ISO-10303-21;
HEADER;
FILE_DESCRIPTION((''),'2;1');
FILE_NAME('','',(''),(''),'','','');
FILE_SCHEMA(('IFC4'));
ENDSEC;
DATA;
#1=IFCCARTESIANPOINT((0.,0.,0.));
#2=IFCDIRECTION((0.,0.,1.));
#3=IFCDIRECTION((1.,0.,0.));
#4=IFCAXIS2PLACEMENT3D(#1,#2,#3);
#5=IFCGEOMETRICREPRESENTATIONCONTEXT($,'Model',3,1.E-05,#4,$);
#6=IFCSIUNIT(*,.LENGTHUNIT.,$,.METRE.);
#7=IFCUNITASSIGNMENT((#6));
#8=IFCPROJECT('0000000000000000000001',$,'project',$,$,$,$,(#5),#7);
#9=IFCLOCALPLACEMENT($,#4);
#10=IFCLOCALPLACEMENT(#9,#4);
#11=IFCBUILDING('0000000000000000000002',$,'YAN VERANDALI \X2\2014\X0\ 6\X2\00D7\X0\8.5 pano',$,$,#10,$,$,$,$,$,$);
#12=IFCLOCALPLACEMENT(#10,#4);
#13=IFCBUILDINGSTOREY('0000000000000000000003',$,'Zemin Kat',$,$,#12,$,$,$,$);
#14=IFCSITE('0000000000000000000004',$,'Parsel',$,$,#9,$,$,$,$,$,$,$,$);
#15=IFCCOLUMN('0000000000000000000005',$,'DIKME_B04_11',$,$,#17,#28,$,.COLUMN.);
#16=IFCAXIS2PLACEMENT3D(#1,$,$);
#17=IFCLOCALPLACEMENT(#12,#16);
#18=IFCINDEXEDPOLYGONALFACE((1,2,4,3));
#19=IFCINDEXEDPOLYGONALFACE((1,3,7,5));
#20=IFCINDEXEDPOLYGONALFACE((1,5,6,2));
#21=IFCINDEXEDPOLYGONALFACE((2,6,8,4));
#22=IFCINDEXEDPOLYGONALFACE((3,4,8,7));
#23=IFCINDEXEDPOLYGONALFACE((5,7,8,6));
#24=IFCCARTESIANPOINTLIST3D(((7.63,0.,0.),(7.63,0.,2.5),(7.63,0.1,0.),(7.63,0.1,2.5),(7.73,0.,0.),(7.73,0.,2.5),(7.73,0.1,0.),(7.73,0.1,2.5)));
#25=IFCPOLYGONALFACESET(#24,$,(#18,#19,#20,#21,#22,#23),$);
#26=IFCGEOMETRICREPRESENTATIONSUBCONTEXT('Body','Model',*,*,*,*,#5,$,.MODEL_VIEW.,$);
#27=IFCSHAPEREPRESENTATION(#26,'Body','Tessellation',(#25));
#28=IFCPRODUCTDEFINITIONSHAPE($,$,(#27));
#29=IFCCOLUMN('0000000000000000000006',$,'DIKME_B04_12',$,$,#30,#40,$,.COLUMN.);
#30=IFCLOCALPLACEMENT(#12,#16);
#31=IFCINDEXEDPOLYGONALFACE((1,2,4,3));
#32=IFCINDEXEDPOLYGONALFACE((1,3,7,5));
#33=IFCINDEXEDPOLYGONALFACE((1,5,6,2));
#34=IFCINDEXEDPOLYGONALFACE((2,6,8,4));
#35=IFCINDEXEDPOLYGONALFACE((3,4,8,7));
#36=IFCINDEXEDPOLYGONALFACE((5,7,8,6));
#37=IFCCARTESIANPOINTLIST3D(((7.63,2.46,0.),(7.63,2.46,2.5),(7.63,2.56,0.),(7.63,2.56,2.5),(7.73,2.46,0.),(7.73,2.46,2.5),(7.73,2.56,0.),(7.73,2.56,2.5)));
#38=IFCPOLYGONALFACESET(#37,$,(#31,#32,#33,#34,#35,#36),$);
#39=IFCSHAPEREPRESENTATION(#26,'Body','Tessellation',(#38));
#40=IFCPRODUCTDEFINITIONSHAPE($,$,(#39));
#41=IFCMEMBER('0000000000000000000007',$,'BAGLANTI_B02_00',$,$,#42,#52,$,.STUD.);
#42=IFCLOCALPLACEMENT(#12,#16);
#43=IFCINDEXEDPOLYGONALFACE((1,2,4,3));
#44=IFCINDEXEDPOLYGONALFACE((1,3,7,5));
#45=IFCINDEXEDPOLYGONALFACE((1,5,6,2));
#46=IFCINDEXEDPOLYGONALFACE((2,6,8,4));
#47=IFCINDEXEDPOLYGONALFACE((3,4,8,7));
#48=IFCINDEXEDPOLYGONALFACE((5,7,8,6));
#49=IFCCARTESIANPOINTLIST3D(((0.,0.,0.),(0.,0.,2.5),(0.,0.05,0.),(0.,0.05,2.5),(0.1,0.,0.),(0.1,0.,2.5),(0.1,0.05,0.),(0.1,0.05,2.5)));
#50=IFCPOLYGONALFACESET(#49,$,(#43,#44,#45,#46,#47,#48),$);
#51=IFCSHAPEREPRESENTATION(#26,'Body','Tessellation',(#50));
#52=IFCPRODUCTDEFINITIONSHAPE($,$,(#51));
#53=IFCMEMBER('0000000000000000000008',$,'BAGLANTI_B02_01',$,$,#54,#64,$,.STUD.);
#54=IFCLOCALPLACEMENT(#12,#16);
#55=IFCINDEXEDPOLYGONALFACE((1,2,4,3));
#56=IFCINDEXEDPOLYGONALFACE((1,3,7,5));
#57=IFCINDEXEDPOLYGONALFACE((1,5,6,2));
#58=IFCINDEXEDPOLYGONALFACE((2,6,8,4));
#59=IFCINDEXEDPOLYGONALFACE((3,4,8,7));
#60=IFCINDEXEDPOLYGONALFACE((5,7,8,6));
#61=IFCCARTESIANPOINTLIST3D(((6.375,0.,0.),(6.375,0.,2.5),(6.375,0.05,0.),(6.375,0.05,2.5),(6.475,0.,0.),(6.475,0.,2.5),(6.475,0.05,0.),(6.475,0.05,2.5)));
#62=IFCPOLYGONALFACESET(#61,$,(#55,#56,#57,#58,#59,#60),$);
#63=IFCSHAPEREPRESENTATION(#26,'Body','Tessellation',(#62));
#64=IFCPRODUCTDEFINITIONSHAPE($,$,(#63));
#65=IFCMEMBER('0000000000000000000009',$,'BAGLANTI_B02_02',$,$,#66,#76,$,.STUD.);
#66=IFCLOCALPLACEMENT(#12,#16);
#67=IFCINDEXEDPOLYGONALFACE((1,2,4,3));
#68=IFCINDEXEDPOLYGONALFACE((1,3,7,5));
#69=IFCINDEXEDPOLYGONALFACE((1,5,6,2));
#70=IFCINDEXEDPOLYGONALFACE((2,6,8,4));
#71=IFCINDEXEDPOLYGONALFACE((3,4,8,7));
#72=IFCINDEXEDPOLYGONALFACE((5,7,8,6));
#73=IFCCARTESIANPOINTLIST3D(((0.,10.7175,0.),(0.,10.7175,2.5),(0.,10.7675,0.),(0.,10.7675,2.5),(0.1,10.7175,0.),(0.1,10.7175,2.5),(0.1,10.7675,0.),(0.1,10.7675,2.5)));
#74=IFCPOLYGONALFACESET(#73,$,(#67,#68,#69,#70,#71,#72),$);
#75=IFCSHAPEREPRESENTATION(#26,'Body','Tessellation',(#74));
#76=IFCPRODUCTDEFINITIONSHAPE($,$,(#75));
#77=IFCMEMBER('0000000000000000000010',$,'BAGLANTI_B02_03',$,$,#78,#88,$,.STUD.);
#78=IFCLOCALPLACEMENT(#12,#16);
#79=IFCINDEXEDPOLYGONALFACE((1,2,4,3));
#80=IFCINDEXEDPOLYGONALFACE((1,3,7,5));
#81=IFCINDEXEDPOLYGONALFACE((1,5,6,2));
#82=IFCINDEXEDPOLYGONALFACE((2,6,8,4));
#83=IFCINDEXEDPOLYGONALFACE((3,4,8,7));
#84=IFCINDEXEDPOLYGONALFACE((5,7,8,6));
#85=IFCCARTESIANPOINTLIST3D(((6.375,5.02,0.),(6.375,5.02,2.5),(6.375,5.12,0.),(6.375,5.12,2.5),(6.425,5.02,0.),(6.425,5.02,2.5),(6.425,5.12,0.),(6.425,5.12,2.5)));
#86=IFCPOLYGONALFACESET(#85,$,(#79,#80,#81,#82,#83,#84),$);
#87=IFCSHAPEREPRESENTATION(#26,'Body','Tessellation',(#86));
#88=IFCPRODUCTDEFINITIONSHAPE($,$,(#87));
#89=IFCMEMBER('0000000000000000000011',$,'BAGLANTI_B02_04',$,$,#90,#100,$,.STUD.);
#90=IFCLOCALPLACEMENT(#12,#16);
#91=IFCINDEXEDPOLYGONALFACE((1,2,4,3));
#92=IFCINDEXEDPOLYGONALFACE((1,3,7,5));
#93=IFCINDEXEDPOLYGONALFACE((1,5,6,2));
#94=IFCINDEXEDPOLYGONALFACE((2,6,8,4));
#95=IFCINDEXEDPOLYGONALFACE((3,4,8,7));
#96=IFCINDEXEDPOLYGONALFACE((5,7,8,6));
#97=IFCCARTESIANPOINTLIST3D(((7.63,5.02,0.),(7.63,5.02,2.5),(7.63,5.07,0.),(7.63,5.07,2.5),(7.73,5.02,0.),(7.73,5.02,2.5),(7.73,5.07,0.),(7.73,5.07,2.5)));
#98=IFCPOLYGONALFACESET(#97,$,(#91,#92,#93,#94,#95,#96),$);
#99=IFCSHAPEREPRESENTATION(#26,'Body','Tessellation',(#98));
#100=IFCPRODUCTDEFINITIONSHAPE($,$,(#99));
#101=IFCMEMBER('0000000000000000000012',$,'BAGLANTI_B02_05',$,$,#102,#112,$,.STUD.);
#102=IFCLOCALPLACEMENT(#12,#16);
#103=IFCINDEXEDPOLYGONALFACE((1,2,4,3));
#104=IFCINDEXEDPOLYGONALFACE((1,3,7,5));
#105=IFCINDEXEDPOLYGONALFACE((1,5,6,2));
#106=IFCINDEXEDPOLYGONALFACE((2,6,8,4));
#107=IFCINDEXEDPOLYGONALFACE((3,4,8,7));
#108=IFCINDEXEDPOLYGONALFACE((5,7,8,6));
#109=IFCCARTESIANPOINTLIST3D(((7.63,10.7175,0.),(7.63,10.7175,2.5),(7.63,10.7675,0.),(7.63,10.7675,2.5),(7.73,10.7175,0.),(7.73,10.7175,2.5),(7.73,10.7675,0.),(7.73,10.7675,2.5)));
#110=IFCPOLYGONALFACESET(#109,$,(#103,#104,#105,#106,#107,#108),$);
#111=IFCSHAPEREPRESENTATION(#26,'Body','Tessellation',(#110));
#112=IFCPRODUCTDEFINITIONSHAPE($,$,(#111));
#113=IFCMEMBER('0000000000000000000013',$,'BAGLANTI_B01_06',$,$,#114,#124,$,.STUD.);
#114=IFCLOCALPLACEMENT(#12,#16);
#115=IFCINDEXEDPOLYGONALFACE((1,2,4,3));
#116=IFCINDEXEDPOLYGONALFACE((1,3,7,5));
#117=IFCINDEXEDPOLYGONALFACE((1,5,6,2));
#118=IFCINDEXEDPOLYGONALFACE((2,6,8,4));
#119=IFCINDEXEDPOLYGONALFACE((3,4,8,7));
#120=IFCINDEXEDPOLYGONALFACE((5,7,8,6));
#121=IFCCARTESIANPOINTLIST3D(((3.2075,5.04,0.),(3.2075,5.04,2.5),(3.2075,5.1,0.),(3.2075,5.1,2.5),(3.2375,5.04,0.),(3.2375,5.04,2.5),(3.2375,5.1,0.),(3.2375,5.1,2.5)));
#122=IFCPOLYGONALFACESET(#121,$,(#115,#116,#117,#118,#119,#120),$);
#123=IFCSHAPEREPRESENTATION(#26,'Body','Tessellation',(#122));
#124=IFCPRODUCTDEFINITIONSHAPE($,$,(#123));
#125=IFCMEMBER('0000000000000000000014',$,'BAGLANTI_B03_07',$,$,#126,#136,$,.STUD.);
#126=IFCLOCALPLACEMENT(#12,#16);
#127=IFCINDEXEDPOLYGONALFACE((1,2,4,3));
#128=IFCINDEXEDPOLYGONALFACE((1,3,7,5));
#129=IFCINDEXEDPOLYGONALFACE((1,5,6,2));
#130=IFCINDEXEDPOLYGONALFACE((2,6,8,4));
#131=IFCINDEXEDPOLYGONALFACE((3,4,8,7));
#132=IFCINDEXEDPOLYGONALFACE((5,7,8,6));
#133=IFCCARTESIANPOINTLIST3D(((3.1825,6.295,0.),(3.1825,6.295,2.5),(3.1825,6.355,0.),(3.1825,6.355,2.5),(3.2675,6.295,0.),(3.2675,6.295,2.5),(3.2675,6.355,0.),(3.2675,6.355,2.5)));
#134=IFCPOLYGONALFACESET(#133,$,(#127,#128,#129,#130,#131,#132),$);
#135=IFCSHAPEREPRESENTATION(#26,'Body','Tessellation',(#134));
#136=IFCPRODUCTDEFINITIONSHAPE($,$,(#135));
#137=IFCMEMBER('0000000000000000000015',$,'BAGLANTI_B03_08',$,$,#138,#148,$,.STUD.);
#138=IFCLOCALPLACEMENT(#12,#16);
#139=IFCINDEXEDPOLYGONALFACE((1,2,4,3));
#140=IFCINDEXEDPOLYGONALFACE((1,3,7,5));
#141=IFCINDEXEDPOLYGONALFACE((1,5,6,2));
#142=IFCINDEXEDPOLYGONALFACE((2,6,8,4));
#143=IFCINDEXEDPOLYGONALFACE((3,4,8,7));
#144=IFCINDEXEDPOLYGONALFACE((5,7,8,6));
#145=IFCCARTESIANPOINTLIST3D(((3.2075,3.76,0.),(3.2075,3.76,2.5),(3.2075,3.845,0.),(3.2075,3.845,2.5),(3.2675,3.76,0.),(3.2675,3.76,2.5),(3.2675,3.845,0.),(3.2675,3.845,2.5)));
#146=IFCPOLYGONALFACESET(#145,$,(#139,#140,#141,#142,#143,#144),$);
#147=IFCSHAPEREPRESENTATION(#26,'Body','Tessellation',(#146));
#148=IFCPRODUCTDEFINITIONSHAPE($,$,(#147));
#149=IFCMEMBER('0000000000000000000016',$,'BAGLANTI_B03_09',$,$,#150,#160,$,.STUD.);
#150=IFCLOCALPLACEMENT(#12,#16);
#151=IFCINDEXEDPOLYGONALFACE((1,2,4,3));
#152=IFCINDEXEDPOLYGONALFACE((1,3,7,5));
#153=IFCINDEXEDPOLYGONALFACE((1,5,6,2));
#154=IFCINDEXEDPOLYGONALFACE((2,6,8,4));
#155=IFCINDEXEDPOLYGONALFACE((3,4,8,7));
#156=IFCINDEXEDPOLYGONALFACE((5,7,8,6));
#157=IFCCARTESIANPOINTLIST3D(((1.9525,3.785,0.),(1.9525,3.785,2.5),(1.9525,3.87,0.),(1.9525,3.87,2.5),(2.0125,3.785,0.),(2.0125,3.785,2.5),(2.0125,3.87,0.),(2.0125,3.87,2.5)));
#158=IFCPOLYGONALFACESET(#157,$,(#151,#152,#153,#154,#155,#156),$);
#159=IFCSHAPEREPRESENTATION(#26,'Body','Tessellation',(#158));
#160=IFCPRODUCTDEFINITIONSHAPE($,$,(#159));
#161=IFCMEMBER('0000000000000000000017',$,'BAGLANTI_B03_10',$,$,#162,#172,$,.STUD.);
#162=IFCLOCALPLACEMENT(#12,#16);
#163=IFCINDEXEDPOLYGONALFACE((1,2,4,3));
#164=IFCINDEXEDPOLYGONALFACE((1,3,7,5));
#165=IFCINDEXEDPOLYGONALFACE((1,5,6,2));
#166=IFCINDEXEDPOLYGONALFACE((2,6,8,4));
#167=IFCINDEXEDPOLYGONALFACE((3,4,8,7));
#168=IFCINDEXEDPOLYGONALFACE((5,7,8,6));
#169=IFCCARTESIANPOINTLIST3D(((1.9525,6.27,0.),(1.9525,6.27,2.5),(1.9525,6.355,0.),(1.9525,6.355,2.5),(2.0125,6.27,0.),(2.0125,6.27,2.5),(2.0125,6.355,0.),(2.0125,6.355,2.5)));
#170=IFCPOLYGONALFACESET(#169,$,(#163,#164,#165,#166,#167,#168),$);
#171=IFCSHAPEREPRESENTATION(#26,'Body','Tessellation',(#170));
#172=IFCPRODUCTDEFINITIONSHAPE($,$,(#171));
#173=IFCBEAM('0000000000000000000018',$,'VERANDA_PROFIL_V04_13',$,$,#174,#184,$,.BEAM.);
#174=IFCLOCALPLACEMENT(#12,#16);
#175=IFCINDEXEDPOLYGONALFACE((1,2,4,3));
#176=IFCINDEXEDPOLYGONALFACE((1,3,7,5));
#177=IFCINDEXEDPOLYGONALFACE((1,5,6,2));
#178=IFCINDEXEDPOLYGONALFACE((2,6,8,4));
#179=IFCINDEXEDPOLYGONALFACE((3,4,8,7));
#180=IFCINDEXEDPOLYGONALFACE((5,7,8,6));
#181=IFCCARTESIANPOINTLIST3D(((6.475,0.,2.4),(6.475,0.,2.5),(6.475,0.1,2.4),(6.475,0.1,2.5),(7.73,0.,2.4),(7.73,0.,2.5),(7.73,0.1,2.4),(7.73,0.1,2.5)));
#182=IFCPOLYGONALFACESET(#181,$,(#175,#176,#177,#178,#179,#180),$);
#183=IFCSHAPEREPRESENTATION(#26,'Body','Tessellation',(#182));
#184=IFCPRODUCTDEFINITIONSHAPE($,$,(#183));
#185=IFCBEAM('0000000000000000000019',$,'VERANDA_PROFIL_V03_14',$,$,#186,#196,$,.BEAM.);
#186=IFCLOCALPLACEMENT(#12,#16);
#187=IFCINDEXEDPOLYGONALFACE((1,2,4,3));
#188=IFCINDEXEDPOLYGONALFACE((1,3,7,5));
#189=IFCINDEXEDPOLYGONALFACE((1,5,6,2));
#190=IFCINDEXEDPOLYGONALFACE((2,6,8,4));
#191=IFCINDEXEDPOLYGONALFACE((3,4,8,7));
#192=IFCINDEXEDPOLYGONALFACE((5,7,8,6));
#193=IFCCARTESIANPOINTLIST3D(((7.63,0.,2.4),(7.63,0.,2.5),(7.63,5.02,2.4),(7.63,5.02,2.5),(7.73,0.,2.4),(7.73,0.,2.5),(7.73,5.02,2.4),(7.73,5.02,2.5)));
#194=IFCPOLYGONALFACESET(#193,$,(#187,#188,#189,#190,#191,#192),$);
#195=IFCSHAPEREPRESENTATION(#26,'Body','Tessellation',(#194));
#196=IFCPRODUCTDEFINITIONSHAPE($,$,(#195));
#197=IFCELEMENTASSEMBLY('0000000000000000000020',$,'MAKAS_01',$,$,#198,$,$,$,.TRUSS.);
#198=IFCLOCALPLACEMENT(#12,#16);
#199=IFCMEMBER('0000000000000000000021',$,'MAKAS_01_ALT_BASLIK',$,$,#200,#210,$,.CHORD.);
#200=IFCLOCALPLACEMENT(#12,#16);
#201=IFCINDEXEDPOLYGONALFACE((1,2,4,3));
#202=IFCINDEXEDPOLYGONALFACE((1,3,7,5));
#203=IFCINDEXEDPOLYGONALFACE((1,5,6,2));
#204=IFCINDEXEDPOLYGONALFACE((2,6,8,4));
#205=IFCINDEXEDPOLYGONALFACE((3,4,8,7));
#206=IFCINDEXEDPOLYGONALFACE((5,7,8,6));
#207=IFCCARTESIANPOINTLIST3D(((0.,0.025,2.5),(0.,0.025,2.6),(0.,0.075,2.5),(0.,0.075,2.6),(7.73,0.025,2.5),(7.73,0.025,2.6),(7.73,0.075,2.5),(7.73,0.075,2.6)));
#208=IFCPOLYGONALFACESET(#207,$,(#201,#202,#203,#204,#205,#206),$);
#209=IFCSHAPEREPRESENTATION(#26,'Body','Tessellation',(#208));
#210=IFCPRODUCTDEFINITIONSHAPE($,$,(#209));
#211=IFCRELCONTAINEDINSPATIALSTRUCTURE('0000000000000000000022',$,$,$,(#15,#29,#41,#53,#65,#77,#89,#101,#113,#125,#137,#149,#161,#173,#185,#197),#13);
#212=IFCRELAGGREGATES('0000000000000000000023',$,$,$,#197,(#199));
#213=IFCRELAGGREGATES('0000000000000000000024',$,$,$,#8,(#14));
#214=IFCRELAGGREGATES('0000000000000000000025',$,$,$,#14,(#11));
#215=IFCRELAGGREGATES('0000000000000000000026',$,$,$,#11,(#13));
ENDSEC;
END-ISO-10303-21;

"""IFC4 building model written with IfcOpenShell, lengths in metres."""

from ifc_helpers import new_model, si_unit, frame, origin_with_axes, place, context, subcontext, project, spatial, line, indexed_curve, outline, extrude, element, aggregate, save


model = new_model("IFC4")

# Units and contexts
model_context = context("Model", 3, precision=1e-05, world=origin_with_axes())
body_context = subcontext(model_context, "Body", "Model", "MODEL_VIEW")
ifc_project = project(units=[si_unit("LENGTHUNIT", "METRE")], contexts=[model_context])

# Site, building, storey
site_placement = place(None, origin_with_axes())
site = spatial("IfcSite", under=ifc_project, at=site_placement, Name="Parsel")
building_placement = place(site_placement, origin_with_axes())
building = spatial("IfcBuilding", under=site, at=building_placement, Name="YAN VERANDALI — 6×8.5 pano")
storey_placement = place(building_placement, origin_with_axes())
storey = spatial("IfcBuildingStorey", under=building, at=storey_placement, Name="Zemin Kat")

# Columns
column_1_placement = place(storey_placement, origin_with_axes())
element("IfcColumn", 1, at=column_1_placement, inside=storey, Name="DIKME_B04_11", PredefinedType="COLUMN", context=body_context, shape_type="SweptSolid", body=[
    extrude(outline(indexed_curve([(7.63, 0.0), (7.73, 0.0), (7.73, 0.1), (7.63, 0.1)], segments=[line(1, 2, 3, 4, 1)])), origin_with_axes(), (0.0, 0.0, 1.0), 2.5),
])
column_2_placement = place(storey_placement, origin_with_axes())
element("IfcColumn", 2, at=column_2_placement, inside=storey, Name="DIKME_B04_12", PredefinedType="COLUMN", context=body_context, shape_type="SweptSolid", body=[
    extrude(outline(indexed_curve([(7.63, 2.46), (7.73, 2.46), (7.73, 2.56), (7.63, 2.56)], segments=[line(1, 2, 3, 4, 1)])), origin_with_axes(), (0.0, 0.0, 1.0), 2.5),
])

# Members
member_1_placement = place(storey_placement, origin_with_axes())
element("IfcMember", 3, at=member_1_placement, inside=storey, Name="BAGLANTI_B02_00", PredefinedType="STUD", context=body_context, shape_type="SweptSolid", body=[
    extrude(outline(indexed_curve([(0.0, 0.0), (0.1, 0.0), (0.1, 0.05), (0.0, 0.05)], segments=[line(1, 2, 3, 4, 1)])), origin_with_axes(), (0.0, 0.0, 1.0), 2.5),
])
member_2_placement = place(storey_placement, origin_with_axes())
element("IfcMember", 4, at=member_2_placement, inside=storey, Name="BAGLANTI_B02_01", PredefinedType="STUD", context=body_context, shape_type="SweptSolid", body=[
    extrude(outline(indexed_curve([(6.375, 0.0), (6.475, 0.0), (6.475, 0.05), (6.375, 0.05)], segments=[line(1, 2, 3, 4, 1)])), origin_with_axes(), (0.0, 0.0, 1.0), 2.5),
])
member_3_placement = place(storey_placement, origin_with_axes())
element("IfcMember", 5, at=member_3_placement, inside=storey, Name="BAGLANTI_B02_02", PredefinedType="STUD", context=body_context, shape_type="SweptSolid", body=[
    extrude(outline(indexed_curve([(0.0, 10.7175), (0.1, 10.7175), (0.1, 10.7675), (0.0, 10.7675)], segments=[line(1, 2, 3, 4, 1)])), origin_with_axes(), (0.0, 0.0, 1.0), 2.5),
])
member_4_placement = place(storey_placement, origin_with_axes())
element("IfcMember", 6, at=member_4_placement, inside=storey, Name="BAGLANTI_B02_03", PredefinedType="STUD", context=body_context, shape_type="SweptSolid", body=[
    extrude(outline(indexed_curve([(6.375, 5.02), (6.425, 5.02), (6.425, 5.12), (6.375, 5.12)], segments=[line(1, 2, 3, 4, 1)])), origin_with_axes(), (0.0, 0.0, 1.0), 2.5),
])
member_5_placement = place(storey_placement, origin_with_axes())
element("IfcMember", 7, at=member_5_placement, inside=storey, Name="BAGLANTI_B02_04", PredefinedType="STUD", context=body_context, shape_type="SweptSolid", body=[
    extrude(outline(indexed_curve([(7.63, 5.02), (7.73, 5.02), (7.73, 5.07), (7.63, 5.07)], segments=[line(1, 2, 3, 4, 1)])), origin_with_axes(), (0.0, 0.0, 1.0), 2.5),
])
member_6_placement = place(storey_placement, origin_with_axes())
element("IfcMember", 8, at=member_6_placement, inside=storey, Name="BAGLANTI_B02_05", PredefinedType="STUD", context=body_context, shape_type="SweptSolid", body=[
    extrude(outline(indexed_curve([(7.63, 10.7175), (7.73, 10.7175), (7.73, 10.7675), (7.63, 10.7675)], segments=[line(1, 2, 3, 4, 1)])), origin_with_axes(), (0.0, 0.0, 1.0), 2.5),
])
member_7_placement = place(storey_placement, origin_with_axes())
element("IfcMember", 9, at=member_7_placement, inside=storey, Name="BAGLANTI_B01_06", PredefinedType="STUD", context=body_context, shape_type="SweptSolid", body=[
    extrude(outline(indexed_curve([(3.2075, 5.04), (3.2375, 5.04), (3.2375, 5.1), (3.2075, 5.1)], segments=[line(1, 2, 3, 4, 1)])), origin_with_axes(), (0.0, 0.0, 1.0), 2.5),
])
member_8_placement = place(storey_placement, origin_with_axes())
element("IfcMember", 10, at=member_8_placement, inside=storey, Name="BAGLANTI_B03_07", PredefinedType="STUD", context=body_context, shape_type="SweptSolid", body=[
    extrude(outline(indexed_curve([(3.1825, 6.295), (3.2675, 6.295), (3.2675, 6.355), (3.1825, 6.355)], segments=[line(1, 2, 3, 4, 1)])), origin_with_axes(), (0.0, 0.0, 1.0), 2.5),
])
member_9_placement = place(storey_placement, origin_with_axes())
element("IfcMember", 11, at=member_9_placement, inside=storey, Name="BAGLANTI_B03_08", PredefinedType="STUD", context=body_context, shape_type="SweptSolid", body=[
    extrude(outline(indexed_curve([(3.2075, 3.76), (3.2675, 3.76), (3.2675, 3.845), (3.2075, 3.845)], segments=[line(1, 2, 3, 4, 1)])), origin_with_axes(), (0.0, 0.0, 1.0), 2.5),
])
member_10_placement = place(storey_placement, origin_with_axes())
element("IfcMember", 12, at=member_10_placement, inside=storey, Name="BAGLANTI_B03_09", PredefinedType="STUD", context=body_context, shape_type="SweptSolid", body=[
    extrude(outline(indexed_curve([(1.9525, 3.785), (2.0125, 3.785), (2.0125, 3.87), (1.9525, 3.87)], segments=[line(1, 2, 3, 4, 1)])), origin_with_axes(), (0.0, 0.0, 1.0), 2.5),
])
member_11_placement = place(storey_placement, origin_with_axes())
element("IfcMember", 13, at=member_11_placement, inside=storey, Name="BAGLANTI_B03_10", PredefinedType="STUD", context=body_context, shape_type="SweptSolid", body=[
    extrude(outline(indexed_curve([(1.9525, 6.27), (2.0125, 6.27), (2.0125, 6.355), (1.9525, 6.355)], segments=[line(1, 2, 3, 4, 1)])), origin_with_axes(), (0.0, 0.0, 1.0), 2.5),
])

# Beams
beam_1_placement = place(storey_placement, origin_with_axes())
element("IfcBeam", 14, at=beam_1_placement, inside=storey, Name="VERANDA_PROFIL_V04_13", PredefinedType="BEAM", context=body_context, shape_type="SweptSolid", body=[
    extrude(outline(indexed_curve([(6.475, 0.0), (7.73, 0.0), (7.73, 0.1), (6.475, 0.1)], segments=[line(1, 2, 3, 4, 1)])), frame((0.0, 0.0, 2.4), z_axis=(0.0, 0.0, 1.0), x_axis=(1.0, 0.0, 0.0)), (0.0, 0.0, 1.0), 0.1),
])
beam_2_placement = place(storey_placement, origin_with_axes())
element("IfcBeam", 15, at=beam_2_placement, inside=storey, Name="VERANDA_PROFIL_V03_14", PredefinedType="BEAM", context=body_context, shape_type="SweptSolid", body=[
    extrude(outline(indexed_curve([(7.63, 0.0), (7.73, 0.0), (7.73, 5.02), (7.63, 5.02)], segments=[line(1, 2, 3, 4, 1)])), frame((0.0, 0.0, 2.4), z_axis=(0.0, 0.0, 1.0), x_axis=(1.0, 0.0, 0.0)), (0.0, 0.0, 1.0), 0.1),
])

# Element assembly, member
assembly_1_placement = place(storey_placement, origin_with_axes())
assembly_1 = element("IfcElementAssembly", 16, at=assembly_1_placement, inside=storey, Name="MAKAS_01", PredefinedType="TRUSS")
member_12_placement = place(assembly_1_placement, origin_with_axes())
member_12 = element("IfcMember", 17, at=member_12_placement, Name="MAKAS_01_ALT_BASLIK", PredefinedType="CHORD", context=body_context, shape_type="SweptSolid", body=[
    extrude(outline(indexed_curve([(0.0, 2.5), (7.73, 2.5), (7.73, 2.6), (0.0, 2.6)], segments=[line(1, 2, 3, 4, 1)])), frame((0.0, 0.075, 0.0), z_axis=(0.0, -1.0, 0.0), x_axis=(1.0, 0.0, 0.0)), (0.0, 0.0, 1.0), 0.05),
])
aggregate(assembly_1, [member_12])

save(model, "model.ifc")
